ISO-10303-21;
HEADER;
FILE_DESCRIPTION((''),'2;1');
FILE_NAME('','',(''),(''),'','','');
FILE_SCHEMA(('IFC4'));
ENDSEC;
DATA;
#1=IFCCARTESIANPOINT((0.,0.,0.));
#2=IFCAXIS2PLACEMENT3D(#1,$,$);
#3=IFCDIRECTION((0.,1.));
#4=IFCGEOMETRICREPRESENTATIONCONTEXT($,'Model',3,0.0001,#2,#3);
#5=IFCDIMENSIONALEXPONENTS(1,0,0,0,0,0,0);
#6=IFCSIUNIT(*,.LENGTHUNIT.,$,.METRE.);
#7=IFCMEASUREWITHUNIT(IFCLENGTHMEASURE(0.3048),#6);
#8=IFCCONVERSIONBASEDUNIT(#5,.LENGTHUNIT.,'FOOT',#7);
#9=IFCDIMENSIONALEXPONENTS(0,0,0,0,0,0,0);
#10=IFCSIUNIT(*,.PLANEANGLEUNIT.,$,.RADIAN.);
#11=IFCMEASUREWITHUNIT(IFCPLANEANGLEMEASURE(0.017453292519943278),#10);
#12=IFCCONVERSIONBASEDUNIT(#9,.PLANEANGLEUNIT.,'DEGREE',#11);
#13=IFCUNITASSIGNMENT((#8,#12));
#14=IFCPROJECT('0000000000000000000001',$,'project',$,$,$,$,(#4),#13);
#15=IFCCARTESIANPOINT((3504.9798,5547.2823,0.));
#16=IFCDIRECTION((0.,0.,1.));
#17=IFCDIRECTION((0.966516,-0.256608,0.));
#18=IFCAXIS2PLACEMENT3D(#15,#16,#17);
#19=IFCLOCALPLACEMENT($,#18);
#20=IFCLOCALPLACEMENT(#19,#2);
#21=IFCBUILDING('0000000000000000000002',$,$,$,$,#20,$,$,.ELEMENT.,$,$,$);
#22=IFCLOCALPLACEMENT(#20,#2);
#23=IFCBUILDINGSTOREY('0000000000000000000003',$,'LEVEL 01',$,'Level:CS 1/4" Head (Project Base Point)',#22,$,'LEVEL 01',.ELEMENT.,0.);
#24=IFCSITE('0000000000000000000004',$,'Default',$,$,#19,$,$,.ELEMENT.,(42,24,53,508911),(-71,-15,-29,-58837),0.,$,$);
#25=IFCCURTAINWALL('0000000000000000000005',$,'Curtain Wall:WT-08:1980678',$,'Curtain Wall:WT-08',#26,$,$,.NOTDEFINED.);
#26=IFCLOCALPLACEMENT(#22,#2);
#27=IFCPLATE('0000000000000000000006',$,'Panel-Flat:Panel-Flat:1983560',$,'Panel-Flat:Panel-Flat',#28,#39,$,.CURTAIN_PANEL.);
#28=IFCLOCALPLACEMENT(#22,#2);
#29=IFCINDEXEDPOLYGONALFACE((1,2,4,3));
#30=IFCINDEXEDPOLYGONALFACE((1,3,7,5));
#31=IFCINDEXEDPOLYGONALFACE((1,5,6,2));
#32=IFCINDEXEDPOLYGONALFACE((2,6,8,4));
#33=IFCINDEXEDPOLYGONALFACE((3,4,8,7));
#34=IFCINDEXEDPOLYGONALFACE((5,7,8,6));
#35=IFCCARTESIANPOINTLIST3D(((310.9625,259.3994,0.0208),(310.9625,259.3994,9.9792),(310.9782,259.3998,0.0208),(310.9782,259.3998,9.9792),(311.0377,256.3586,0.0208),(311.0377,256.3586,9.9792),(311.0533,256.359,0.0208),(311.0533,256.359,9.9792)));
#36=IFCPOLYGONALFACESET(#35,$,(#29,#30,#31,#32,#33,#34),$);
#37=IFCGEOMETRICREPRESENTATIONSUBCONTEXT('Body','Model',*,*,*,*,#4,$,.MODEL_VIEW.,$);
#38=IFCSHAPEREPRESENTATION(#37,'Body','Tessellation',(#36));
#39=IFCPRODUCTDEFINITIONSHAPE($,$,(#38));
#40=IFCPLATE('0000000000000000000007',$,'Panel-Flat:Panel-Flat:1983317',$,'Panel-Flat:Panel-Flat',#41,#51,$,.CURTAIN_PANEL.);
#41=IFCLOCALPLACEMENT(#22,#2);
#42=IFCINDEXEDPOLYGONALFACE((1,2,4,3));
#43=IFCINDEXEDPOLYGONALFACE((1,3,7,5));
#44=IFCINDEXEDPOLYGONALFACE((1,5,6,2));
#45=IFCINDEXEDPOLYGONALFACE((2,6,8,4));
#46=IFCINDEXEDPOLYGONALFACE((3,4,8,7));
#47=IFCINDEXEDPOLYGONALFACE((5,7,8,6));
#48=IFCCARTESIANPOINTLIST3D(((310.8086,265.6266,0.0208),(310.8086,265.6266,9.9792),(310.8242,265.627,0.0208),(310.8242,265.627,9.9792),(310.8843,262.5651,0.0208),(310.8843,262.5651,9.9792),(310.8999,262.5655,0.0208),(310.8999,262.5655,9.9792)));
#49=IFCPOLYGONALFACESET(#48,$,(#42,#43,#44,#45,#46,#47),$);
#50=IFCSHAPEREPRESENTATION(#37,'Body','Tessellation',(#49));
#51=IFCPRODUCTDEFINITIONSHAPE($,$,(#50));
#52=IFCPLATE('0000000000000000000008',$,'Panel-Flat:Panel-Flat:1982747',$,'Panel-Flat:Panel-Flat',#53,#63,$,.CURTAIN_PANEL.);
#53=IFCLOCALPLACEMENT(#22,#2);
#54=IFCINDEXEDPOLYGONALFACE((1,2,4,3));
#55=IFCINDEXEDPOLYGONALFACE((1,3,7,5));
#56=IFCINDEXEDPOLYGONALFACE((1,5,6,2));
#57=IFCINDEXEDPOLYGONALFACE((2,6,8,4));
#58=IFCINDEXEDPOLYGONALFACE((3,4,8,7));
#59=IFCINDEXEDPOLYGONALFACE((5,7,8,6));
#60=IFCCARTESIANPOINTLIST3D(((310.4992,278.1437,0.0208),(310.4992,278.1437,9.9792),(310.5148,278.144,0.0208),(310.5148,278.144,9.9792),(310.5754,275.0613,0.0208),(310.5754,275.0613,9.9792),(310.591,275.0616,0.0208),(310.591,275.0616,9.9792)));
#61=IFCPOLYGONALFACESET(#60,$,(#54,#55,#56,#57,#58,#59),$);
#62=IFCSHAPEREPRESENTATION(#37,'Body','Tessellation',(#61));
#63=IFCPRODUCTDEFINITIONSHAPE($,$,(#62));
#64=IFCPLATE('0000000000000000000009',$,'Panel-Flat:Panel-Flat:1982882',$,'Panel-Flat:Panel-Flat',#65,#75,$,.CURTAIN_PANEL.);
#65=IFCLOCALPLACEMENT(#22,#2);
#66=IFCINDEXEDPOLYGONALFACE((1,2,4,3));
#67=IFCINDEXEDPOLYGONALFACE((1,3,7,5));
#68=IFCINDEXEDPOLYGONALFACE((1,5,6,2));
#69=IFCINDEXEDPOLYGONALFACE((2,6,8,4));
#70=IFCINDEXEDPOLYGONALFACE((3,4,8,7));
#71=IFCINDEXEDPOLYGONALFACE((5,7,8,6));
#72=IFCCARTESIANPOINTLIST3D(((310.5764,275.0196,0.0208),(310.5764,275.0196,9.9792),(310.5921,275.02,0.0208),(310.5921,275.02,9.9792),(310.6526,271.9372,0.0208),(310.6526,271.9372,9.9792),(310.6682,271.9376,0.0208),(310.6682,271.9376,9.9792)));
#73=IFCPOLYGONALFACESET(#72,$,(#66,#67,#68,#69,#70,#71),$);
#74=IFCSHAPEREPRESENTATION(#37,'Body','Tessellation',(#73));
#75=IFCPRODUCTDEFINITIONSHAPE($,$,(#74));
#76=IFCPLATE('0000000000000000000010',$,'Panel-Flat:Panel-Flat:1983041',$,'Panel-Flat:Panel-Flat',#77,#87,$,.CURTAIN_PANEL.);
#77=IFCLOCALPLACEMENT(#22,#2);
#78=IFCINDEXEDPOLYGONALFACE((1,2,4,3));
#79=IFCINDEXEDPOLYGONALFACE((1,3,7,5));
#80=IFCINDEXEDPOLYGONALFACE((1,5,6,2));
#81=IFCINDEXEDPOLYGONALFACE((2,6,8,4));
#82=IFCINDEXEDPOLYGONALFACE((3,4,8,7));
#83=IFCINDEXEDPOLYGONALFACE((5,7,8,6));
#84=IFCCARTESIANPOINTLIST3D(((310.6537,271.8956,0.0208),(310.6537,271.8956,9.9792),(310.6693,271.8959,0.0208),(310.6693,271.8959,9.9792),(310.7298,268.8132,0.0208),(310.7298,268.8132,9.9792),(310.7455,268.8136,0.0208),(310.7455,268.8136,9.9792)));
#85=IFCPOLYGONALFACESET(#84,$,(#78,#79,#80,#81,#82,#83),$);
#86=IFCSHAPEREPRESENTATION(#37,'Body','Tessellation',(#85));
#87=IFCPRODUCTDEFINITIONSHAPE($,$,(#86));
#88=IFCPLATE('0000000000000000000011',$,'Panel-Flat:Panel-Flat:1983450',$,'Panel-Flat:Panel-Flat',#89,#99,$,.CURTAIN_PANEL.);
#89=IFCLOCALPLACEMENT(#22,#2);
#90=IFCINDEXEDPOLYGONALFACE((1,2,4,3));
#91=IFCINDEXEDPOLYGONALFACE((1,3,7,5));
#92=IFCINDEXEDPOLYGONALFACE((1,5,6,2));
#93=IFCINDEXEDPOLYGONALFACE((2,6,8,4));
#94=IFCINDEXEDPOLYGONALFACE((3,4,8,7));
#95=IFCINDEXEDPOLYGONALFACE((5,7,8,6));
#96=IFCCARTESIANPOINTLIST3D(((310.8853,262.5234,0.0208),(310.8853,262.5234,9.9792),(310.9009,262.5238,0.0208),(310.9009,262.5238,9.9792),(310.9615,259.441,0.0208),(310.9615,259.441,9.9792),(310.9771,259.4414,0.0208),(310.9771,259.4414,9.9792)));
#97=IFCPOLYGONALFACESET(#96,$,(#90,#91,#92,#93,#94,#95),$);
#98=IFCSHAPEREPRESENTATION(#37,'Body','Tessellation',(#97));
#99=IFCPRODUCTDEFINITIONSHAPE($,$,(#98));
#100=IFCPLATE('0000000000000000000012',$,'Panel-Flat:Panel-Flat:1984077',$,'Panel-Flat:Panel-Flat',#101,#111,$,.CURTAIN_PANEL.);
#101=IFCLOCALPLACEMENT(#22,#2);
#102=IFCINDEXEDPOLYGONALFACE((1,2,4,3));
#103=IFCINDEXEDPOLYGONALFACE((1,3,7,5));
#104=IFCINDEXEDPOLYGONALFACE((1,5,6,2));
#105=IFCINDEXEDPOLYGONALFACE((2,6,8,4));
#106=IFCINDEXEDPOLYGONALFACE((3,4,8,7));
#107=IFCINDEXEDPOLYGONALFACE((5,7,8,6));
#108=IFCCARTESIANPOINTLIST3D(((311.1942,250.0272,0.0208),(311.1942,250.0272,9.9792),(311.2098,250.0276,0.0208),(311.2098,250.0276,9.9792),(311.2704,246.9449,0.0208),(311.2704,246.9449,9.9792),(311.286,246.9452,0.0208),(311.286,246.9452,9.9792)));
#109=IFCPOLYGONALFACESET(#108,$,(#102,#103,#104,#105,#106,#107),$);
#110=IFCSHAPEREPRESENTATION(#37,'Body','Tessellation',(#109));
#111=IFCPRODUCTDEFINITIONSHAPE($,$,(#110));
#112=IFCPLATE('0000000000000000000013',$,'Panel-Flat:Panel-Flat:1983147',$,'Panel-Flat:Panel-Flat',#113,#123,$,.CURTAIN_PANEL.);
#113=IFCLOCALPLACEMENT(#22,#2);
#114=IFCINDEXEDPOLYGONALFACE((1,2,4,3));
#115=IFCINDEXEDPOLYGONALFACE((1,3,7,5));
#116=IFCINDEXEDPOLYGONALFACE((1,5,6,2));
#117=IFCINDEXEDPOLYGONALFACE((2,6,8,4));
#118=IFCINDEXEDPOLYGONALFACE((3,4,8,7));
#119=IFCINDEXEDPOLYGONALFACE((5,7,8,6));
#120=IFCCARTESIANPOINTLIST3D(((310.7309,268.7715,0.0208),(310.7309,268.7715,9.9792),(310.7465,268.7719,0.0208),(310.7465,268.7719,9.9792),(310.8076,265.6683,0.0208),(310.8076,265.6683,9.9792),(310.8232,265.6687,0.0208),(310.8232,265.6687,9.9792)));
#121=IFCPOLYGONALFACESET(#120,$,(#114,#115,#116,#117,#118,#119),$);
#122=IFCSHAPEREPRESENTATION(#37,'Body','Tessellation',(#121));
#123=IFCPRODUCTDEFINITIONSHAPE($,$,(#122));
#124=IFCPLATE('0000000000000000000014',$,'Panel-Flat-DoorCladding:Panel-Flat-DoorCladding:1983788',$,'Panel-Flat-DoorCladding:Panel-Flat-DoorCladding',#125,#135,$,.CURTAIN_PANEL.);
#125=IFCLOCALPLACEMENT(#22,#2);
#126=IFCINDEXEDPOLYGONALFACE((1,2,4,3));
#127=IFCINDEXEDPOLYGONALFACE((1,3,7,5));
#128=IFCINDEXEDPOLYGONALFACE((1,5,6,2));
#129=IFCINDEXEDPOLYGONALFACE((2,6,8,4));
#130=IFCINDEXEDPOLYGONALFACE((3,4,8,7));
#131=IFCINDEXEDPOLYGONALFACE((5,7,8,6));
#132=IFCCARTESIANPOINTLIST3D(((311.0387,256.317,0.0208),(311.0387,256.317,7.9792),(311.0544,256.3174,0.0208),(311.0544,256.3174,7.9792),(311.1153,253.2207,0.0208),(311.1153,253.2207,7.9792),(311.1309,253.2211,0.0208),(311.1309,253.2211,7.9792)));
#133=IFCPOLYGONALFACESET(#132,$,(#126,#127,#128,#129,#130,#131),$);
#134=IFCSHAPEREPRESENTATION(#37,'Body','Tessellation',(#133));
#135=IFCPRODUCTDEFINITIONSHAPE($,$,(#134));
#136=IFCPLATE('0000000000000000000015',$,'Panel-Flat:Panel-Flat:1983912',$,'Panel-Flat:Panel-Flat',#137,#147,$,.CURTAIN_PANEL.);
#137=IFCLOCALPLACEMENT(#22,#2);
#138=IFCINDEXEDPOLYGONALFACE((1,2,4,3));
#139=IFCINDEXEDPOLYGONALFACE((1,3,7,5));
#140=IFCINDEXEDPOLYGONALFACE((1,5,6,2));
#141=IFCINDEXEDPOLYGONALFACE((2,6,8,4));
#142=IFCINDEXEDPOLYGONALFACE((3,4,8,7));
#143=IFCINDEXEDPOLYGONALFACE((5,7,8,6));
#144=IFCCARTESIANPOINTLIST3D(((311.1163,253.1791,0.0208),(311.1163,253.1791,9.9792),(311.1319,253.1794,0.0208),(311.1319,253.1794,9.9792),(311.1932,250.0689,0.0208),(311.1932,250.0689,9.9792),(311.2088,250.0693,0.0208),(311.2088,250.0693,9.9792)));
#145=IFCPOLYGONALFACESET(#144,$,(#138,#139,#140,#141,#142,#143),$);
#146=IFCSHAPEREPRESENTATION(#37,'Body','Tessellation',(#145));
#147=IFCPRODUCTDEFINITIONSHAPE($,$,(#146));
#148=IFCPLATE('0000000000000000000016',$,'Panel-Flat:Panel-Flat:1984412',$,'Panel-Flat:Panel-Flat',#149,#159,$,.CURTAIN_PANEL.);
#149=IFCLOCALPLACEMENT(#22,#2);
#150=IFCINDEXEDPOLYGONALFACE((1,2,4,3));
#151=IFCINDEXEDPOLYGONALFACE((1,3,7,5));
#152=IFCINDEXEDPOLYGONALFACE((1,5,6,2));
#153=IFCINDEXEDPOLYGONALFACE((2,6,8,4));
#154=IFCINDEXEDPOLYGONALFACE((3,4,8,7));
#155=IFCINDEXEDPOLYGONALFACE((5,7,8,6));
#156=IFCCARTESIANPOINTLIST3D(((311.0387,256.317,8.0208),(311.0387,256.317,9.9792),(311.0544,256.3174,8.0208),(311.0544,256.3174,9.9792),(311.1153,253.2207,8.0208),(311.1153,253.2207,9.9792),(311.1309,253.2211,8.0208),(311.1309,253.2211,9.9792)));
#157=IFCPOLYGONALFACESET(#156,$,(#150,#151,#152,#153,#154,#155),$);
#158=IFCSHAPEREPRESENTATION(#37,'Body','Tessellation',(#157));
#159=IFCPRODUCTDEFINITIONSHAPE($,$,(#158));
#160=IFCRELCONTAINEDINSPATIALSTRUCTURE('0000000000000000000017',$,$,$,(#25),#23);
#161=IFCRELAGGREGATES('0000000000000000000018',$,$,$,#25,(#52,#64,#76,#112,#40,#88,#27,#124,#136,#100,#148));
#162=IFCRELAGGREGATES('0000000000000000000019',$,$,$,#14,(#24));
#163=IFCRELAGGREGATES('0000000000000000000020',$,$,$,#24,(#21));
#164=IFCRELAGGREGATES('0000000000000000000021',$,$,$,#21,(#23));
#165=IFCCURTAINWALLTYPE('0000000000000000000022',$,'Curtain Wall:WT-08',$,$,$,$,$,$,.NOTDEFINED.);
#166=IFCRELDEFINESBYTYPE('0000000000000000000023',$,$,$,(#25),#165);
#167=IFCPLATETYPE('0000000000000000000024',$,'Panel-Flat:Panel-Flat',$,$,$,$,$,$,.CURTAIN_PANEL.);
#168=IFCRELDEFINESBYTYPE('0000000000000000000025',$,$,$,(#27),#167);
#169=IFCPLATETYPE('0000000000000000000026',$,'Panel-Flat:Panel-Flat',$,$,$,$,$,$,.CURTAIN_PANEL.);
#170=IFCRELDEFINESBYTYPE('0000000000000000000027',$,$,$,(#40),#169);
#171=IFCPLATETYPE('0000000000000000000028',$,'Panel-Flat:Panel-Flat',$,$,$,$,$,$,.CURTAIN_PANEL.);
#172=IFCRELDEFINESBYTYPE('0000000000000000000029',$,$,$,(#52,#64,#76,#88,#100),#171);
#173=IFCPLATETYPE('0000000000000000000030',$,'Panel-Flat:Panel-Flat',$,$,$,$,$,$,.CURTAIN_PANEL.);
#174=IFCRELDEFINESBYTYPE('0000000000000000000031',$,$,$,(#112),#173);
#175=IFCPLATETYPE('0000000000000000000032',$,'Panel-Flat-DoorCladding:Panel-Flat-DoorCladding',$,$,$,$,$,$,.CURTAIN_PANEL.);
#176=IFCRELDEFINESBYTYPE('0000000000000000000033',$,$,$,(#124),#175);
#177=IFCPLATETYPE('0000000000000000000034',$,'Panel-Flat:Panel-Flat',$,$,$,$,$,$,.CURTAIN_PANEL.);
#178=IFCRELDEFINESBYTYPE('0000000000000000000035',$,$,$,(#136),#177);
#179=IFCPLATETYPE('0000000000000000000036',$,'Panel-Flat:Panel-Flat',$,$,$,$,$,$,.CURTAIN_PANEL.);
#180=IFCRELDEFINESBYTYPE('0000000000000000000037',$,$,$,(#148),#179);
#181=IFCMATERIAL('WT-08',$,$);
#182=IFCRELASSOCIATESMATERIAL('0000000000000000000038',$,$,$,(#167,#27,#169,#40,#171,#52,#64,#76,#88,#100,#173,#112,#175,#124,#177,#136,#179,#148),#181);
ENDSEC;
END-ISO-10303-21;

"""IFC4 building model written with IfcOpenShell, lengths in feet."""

from ifc_helpers import new_model, entity, si_unit, converted_unit, direction, frame, origin, place, context, subcontext, project, spatial, indexed_curve, outline, extrude, source, transform, mapped, material, type_object, type_shapes, element, aggregate, save


model = new_model("IFC4")

# Units and contexts
model_context = context("Model", 3, precision=0.0001, world=origin(), true_north=direction((0.0, 1.0)))
body_context = subcontext(model_context, "Body", "Model", "MODEL_VIEW")
ifc_project = project(units=[converted_unit("LENGTHUNIT", "FOOT", entity("IfcLengthMeasure", 0.3048), si_unit("LENGTHUNIT", "METRE"), dimensions=[1, 0, 0, 0, 0, 0, 0]), converted_unit("PLANEANGLEUNIT", "DEGREE", entity("IfcPlaneAngleMeasure", 0.017453292519943278), si_unit("PLANEANGLEUNIT", "RADIAN"), dimensions=[0, 0, 0, 0, 0, 0, 0])], contexts=[model_context])

# Site, building, storey
site_placement = place(None, frame((3504.9798, 5547.2823, 0.0), z_axis=(0.0, 0.0, 1.0), x_axis=(0.966516, -0.256608, 0.0)))
site = spatial("IfcSite", under=ifc_project, at=site_placement, Name="Default", CompositionType="ELEMENT", RefLatitude=(42, 24, 53, 508911), RefLongitude=(-71, -15, -29, -58837), RefElevation=0.0)
building_placement = place(site_placement, origin())
building = spatial("IfcBuilding", under=site, at=building_placement, CompositionType="ELEMENT")
storey_placement = place(building_placement, origin())
storey = spatial("IfcBuildingStorey", under=building, at=storey_placement, Name="LEVEL 01", ObjectType="Level:CS 1/4\" Head (Project Base Point)", LongName="LEVEL 01", CompositionType="ELEMENT", Elevation=0.0)

# Curtain wall, plates
curtain_wall_type_1 = type_object("IfcCurtainWallType", Name="Curtain Wall:WT-08", PredefinedType="NOTDEFINED")
curtain_wall_1_placement = place(storey_placement, origin())
curtain_wall_1 = element("IfcCurtainWall", 1, at=curtain_wall_1_placement, inside=storey, type_object=curtain_wall_type_1, Name="Curtain Wall:WT-08:1980678", ObjectType="Curtain Wall:WT-08", PredefinedType="NOTDEFINED")
ifc_material_1 = material(Name="WT-08")
plate_type_1 = type_object("IfcPlateType", Name="Panel-Flat:Panel-Flat", PredefinedType="CURTAIN_PANEL", material=ifc_material_1)
shared_shape_1 = source(origin(), body_context, "Body", "SweptSolid", [
    extrude(outline(indexed_curve([(-0.0078, -1.5208), (0.0078, -1.5208), (0.0078, 1.5208), (-0.0078, 1.5208), (-0.0078, -1.5208)], self_intersect=False)), frame((0.0, -0.0078, 0.0208), z_axis=(0.0, 0.0, 1.0), x_axis=(0.0, -1.0, 0.0)), (0.0, 0.0, 1.0), 9.9583),
])
type_shapes(plate_type_1, [shared_shape_1])
plate_1_placement = place(curtain_wall_1_placement, frame((311.0157, 257.8794, 0.0), z_axis=(0.0, 0.0, 1.0), x_axis=(0.024711, -0.999695, 0.0)))
plate_1 = element("IfcPlate", 2, at=plate_1_placement, type_object=plate_type_1, material=ifc_material_1, Name="Panel-Flat:Panel-Flat:1983560", ObjectType="Panel-Flat:Panel-Flat", PredefinedType="CURTAIN_PANEL", context=body_context, shape_type="MappedRepresentation", body=[
    mapped(shared_shape_1, transform((0.0, 0.0, 0.0), scale=1.0)),
])
plate_type_2 = type_object("IfcPlateType", Name="Panel-Flat:Panel-Flat", PredefinedType="CURTAIN_PANEL", material=ifc_material_1)
shared_shape_2 = source(origin(), body_context, "Body", "SweptSolid", [
    extrude(outline(indexed_curve([(-0.0078, -1.5313), (0.0078, -1.5313), (0.0078, 1.5313), (-0.0078, 1.5313), (-0.0078, -1.5313)], self_intersect=False)), frame((0.0, -0.0078, 0.0208), z_axis=(0.0, 0.0, 1.0), x_axis=(0.0, -1.0, 0.0)), (0.0, 0.0, 1.0), 9.9583),
])
type_shapes(plate_type_2, [shared_shape_2])
plate_2_placement = place(curtain_wall_1_placement, frame((310.8621, 264.0962, 0.0), z_axis=(0.0, 0.0, 1.0), x_axis=(0.024711, -0.999695, 0.0)))
plate_2 = element("IfcPlate", 3, at=plate_2_placement, type_object=plate_type_2, material=ifc_material_1, Name="Panel-Flat:Panel-Flat:1983317", ObjectType="Panel-Flat:Panel-Flat", PredefinedType="CURTAIN_PANEL", context=body_context, shape_type="MappedRepresentation", body=[
    mapped(shared_shape_2, transform((0.0, 0.0, 0.0), scale=1.0)),
])
plate_type_3 = type_object("IfcPlateType", Name="Panel-Flat:Panel-Flat", PredefinedType="CURTAIN_PANEL", material=ifc_material_1)
shared_shape_3 = source(origin(), body_context, "Body", "SweptSolid", [
    extrude(outline(indexed_curve([(-0.0078, -1.5417), (0.0078, -1.5417), (0.0078, 1.5417), (-0.0078, 1.5417), (-0.0078, -1.5417)], self_intersect=False)), frame((0.0, -0.0078, 0.0208), z_axis=(0.0, 0.0, 1.0), x_axis=(0.0, -1.0, 0.0)), (0.0, 0.0, 1.0), 9.9583),
])
type_shapes(plate_type_3, [shared_shape_3])
plate_3_placement = place(curtain_wall_1_placement, frame((310.5529, 276.6028, 0.0), z_axis=(0.0, 0.0, 1.0), x_axis=(0.024711, -0.999695, 0.0)))
plate_3 = element("IfcPlate", 4, at=plate_3_placement, type_object=plate_type_3, material=ifc_material_1, Name="Panel-Flat:Panel-Flat:1982747", ObjectType="Panel-Flat:Panel-Flat", PredefinedType="CURTAIN_PANEL", context=body_context, shape_type="MappedRepresentation", body=[
    mapped(shared_shape_3, transform((0.0, 0.0, 0.0), scale=1.0)),
])
plate_4_placement = place(curtain_wall_1_placement, frame((310.6301, 273.4788, 0.0), z_axis=(0.0, 0.0, 1.0), x_axis=(0.024711, -0.999695, 0.0)))
plate_4 = element("IfcPlate", 5, at=plate_4_placement, type_object=plate_type_3, material=ifc_material_1, Name="Panel-Flat:Panel-Flat:1982882", ObjectType="Panel-Flat:Panel-Flat", PredefinedType="CURTAIN_PANEL", context=body_context, shape_type="MappedRepresentation", body=[
    mapped(shared_shape_3, transform((0.0, 0.0, 0.0), scale=1.0)),
])
plate_5_placement = place(curtain_wall_1_placement, frame((310.7074, 270.3548, 0.0), z_axis=(0.0, 0.0, 1.0), x_axis=(0.024711, -0.999695, 0.0)))
plate_5 = element("IfcPlate", 6, at=plate_5_placement, type_object=plate_type_3, material=ifc_material_1, Name="Panel-Flat:Panel-Flat:1983041", ObjectType="Panel-Flat:Panel-Flat", PredefinedType="CURTAIN_PANEL", context=body_context, shape_type="MappedRepresentation", body=[
    mapped(shared_shape_3, transform((0.0, 0.0, 0.0), scale=1.0)),
])
plate_6_placement = place(curtain_wall_1_placement, frame((310.939, 260.9826, 0.0), z_axis=(0.0, 0.0, 1.0), x_axis=(0.024711, -0.999695, 0.0)))
plate_6 = element("IfcPlate", 7, at=plate_6_placement, type_object=plate_type_3, material=ifc_material_1, Name="Panel-Flat:Panel-Flat:1983450", ObjectType="Panel-Flat:Panel-Flat", PredefinedType="CURTAIN_PANEL", context=body_context, shape_type="MappedRepresentation", body=[
    mapped(shared_shape_3, transform((0.0, 0.0, 0.0), scale=1.0)),
])
plate_7_placement = place(curtain_wall_1_placement, frame((311.2479, 248.4864, 0.0), z_axis=(0.0, 0.0, 1.0), x_axis=(0.024711, -0.999695, 0.0)))
plate_7 = element("IfcPlate", 8, at=plate_7_placement, type_object=plate_type_3, material=ifc_material_1, Name="Panel-Flat:Panel-Flat:1984077", ObjectType="Panel-Flat:Panel-Flat", PredefinedType="CURTAIN_PANEL", context=body_context, shape_type="MappedRepresentation", body=[
    mapped(shared_shape_3, transform((0.0, 0.0, 0.0), scale=1.0)),
])
plate_type_4 = type_object("IfcPlateType", Name="Panel-Flat:Panel-Flat", PredefinedType="CURTAIN_PANEL", material=ifc_material_1)
shared_shape_4 = source(origin(), body_context, "Body", "SweptSolid", [
    extrude(outline(indexed_curve([(-0.0078, -1.5521), (0.0078, -1.5521), (0.0078, 1.5521), (-0.0078, 1.5521), (-0.0078, -1.5521)], self_intersect=False)), frame((0.0, -0.0078, 0.0208), z_axis=(0.0, 0.0, 1.0), x_axis=(0.0, -1.0, 0.0)), (0.0, 0.0, 1.0), 9.9583),
])
type_shapes(plate_type_4, [shared_shape_4])
plate_8_placement = place(curtain_wall_1_placement, frame((310.7848, 267.2203, 0.0), z_axis=(0.0, 0.0, 1.0), x_axis=(0.024711, -0.999695, 0.0)))
plate_8 = element("IfcPlate", 9, at=plate_8_placement, type_object=plate_type_4, material=ifc_material_1, Name="Panel-Flat:Panel-Flat:1983147", ObjectType="Panel-Flat:Panel-Flat", PredefinedType="CURTAIN_PANEL", context=body_context, shape_type="MappedRepresentation", body=[
    mapped(shared_shape_4, transform((0.0, 0.0, 0.0), scale=1.0)),
])
plate_type_5 = type_object("IfcPlateType", Name="Panel-Flat-DoorCladding:Panel-Flat-DoorCladding", PredefinedType="CURTAIN_PANEL", material=ifc_material_1)
shared_shape_5 = source(origin(), body_context, "Body", "SweptSolid", [
    extrude(outline(indexed_curve([(-0.0078, -1.5486), (0.0078, -1.5486), (0.0078, 1.5486), (-0.0078, 1.5486), (-0.0078, -1.5486)], self_intersect=False)), frame((0.0, -0.0078, 0.0208), z_axis=(0.0, 0.0, 1.0), x_axis=(0.0, -1.0, 0.0)), (0.0, 0.0, 1.0), 7.9583),
])
type_shapes(plate_type_5, [shared_shape_5])
plate_9_placement = place(curtain_wall_1_placement, frame((311.0926, 254.7692, 0.0), z_axis=(0.0, 0.0, 1.0), x_axis=(0.024711, -0.999695, 0.0)))
plate_9 = element("IfcPlate", 10, at=plate_9_placement, type_object=plate_type_5, material=ifc_material_1, Name="Panel-Flat-DoorCladding:Panel-Flat-DoorCladding:1983788", ObjectType="Panel-Flat-DoorCladding:Panel-Flat-DoorCladding", PredefinedType="CURTAIN_PANEL", context=body_context, shape_type="MappedRepresentation", body=[
    mapped(shared_shape_5, transform((0.0, 0.0, 0.0), scale=1.0)),
])
plate_type_6 = type_object("IfcPlateType", Name="Panel-Flat:Panel-Flat", PredefinedType="CURTAIN_PANEL", material=ifc_material_1)
shared_shape_6 = source(origin(), body_context, "Body", "SweptSolid", [
    extrude(outline(indexed_curve([(-0.0078, -1.5556), (0.0078, -1.5556), (0.0078, 1.5556), (-0.0078, 1.5556), (-0.0078, -1.5556)], self_intersect=False)), frame((0.0, -0.0078, 0.0208), z_axis=(0.0, 0.0, 1.0), x_axis=(0.0, -1.0, 0.0)), (0.0, 0.0, 1.0), 9.9583),
])
type_shapes(plate_type_6, [shared_shape_6])
plate_10_placement = place(curtain_wall_1_placement, frame((311.1704, 251.6244, 0.0), z_axis=(0.0, 0.0, 1.0), x_axis=(0.024711, -0.999695, 0.0)))
plate_10 = element("IfcPlate", 11, at=plate_10_placement, type_object=plate_type_6, material=ifc_material_1, Name="Panel-Flat:Panel-Flat:1983912", ObjectType="Panel-Flat:Panel-Flat", PredefinedType="CURTAIN_PANEL", context=body_context, shape_type="MappedRepresentation", body=[
    mapped(shared_shape_6, transform((0.0, 0.0, 0.0), scale=1.0)),
])
plate_type_7 = type_object("IfcPlateType", Name="Panel-Flat:Panel-Flat", PredefinedType="CURTAIN_PANEL", material=ifc_material_1)
shared_shape_7 = source(origin(), body_context, "Body", "SweptSolid", [
    extrude(outline(indexed_curve([(-0.0078, -1.5486), (0.0078, -1.5486), (0.0078, 1.5486), (-0.0078, 1.5486), (-0.0078, -1.5486)], self_intersect=False)), frame((0.0, -0.0078, 0.0208), z_axis=(0.0, 0.0, 1.0), x_axis=(0.0, -1.0, 0.0)), (0.0, 0.0, 1.0), 1.9583),
])
type_shapes(plate_type_7, [shared_shape_7])
plate_11_placement = place(curtain_wall_1_placement, frame((311.0926, 254.7692, 8.0), z_axis=(0.0, 0.0, 1.0), x_axis=(0.024711, -0.999695, 0.0)))
plate_11 = element("IfcPlate", 12, at=plate_11_placement, type_object=plate_type_7, material=ifc_material_1, Name="Panel-Flat:Panel-Flat:1984412", ObjectType="Panel-Flat:Panel-Flat", PredefinedType="CURTAIN_PANEL", context=body_context, shape_type="MappedRepresentation", body=[
    mapped(shared_shape_7, transform((0.0, 0.0, 0.0), scale=1.0)),
])

aggregate(curtain_wall_1, [plate_3, plate_4, plate_5, plate_8, plate_2, plate_6, plate_1, plate_9, plate_10, plate_7, plate_11])

save(model, "model.ifc")
